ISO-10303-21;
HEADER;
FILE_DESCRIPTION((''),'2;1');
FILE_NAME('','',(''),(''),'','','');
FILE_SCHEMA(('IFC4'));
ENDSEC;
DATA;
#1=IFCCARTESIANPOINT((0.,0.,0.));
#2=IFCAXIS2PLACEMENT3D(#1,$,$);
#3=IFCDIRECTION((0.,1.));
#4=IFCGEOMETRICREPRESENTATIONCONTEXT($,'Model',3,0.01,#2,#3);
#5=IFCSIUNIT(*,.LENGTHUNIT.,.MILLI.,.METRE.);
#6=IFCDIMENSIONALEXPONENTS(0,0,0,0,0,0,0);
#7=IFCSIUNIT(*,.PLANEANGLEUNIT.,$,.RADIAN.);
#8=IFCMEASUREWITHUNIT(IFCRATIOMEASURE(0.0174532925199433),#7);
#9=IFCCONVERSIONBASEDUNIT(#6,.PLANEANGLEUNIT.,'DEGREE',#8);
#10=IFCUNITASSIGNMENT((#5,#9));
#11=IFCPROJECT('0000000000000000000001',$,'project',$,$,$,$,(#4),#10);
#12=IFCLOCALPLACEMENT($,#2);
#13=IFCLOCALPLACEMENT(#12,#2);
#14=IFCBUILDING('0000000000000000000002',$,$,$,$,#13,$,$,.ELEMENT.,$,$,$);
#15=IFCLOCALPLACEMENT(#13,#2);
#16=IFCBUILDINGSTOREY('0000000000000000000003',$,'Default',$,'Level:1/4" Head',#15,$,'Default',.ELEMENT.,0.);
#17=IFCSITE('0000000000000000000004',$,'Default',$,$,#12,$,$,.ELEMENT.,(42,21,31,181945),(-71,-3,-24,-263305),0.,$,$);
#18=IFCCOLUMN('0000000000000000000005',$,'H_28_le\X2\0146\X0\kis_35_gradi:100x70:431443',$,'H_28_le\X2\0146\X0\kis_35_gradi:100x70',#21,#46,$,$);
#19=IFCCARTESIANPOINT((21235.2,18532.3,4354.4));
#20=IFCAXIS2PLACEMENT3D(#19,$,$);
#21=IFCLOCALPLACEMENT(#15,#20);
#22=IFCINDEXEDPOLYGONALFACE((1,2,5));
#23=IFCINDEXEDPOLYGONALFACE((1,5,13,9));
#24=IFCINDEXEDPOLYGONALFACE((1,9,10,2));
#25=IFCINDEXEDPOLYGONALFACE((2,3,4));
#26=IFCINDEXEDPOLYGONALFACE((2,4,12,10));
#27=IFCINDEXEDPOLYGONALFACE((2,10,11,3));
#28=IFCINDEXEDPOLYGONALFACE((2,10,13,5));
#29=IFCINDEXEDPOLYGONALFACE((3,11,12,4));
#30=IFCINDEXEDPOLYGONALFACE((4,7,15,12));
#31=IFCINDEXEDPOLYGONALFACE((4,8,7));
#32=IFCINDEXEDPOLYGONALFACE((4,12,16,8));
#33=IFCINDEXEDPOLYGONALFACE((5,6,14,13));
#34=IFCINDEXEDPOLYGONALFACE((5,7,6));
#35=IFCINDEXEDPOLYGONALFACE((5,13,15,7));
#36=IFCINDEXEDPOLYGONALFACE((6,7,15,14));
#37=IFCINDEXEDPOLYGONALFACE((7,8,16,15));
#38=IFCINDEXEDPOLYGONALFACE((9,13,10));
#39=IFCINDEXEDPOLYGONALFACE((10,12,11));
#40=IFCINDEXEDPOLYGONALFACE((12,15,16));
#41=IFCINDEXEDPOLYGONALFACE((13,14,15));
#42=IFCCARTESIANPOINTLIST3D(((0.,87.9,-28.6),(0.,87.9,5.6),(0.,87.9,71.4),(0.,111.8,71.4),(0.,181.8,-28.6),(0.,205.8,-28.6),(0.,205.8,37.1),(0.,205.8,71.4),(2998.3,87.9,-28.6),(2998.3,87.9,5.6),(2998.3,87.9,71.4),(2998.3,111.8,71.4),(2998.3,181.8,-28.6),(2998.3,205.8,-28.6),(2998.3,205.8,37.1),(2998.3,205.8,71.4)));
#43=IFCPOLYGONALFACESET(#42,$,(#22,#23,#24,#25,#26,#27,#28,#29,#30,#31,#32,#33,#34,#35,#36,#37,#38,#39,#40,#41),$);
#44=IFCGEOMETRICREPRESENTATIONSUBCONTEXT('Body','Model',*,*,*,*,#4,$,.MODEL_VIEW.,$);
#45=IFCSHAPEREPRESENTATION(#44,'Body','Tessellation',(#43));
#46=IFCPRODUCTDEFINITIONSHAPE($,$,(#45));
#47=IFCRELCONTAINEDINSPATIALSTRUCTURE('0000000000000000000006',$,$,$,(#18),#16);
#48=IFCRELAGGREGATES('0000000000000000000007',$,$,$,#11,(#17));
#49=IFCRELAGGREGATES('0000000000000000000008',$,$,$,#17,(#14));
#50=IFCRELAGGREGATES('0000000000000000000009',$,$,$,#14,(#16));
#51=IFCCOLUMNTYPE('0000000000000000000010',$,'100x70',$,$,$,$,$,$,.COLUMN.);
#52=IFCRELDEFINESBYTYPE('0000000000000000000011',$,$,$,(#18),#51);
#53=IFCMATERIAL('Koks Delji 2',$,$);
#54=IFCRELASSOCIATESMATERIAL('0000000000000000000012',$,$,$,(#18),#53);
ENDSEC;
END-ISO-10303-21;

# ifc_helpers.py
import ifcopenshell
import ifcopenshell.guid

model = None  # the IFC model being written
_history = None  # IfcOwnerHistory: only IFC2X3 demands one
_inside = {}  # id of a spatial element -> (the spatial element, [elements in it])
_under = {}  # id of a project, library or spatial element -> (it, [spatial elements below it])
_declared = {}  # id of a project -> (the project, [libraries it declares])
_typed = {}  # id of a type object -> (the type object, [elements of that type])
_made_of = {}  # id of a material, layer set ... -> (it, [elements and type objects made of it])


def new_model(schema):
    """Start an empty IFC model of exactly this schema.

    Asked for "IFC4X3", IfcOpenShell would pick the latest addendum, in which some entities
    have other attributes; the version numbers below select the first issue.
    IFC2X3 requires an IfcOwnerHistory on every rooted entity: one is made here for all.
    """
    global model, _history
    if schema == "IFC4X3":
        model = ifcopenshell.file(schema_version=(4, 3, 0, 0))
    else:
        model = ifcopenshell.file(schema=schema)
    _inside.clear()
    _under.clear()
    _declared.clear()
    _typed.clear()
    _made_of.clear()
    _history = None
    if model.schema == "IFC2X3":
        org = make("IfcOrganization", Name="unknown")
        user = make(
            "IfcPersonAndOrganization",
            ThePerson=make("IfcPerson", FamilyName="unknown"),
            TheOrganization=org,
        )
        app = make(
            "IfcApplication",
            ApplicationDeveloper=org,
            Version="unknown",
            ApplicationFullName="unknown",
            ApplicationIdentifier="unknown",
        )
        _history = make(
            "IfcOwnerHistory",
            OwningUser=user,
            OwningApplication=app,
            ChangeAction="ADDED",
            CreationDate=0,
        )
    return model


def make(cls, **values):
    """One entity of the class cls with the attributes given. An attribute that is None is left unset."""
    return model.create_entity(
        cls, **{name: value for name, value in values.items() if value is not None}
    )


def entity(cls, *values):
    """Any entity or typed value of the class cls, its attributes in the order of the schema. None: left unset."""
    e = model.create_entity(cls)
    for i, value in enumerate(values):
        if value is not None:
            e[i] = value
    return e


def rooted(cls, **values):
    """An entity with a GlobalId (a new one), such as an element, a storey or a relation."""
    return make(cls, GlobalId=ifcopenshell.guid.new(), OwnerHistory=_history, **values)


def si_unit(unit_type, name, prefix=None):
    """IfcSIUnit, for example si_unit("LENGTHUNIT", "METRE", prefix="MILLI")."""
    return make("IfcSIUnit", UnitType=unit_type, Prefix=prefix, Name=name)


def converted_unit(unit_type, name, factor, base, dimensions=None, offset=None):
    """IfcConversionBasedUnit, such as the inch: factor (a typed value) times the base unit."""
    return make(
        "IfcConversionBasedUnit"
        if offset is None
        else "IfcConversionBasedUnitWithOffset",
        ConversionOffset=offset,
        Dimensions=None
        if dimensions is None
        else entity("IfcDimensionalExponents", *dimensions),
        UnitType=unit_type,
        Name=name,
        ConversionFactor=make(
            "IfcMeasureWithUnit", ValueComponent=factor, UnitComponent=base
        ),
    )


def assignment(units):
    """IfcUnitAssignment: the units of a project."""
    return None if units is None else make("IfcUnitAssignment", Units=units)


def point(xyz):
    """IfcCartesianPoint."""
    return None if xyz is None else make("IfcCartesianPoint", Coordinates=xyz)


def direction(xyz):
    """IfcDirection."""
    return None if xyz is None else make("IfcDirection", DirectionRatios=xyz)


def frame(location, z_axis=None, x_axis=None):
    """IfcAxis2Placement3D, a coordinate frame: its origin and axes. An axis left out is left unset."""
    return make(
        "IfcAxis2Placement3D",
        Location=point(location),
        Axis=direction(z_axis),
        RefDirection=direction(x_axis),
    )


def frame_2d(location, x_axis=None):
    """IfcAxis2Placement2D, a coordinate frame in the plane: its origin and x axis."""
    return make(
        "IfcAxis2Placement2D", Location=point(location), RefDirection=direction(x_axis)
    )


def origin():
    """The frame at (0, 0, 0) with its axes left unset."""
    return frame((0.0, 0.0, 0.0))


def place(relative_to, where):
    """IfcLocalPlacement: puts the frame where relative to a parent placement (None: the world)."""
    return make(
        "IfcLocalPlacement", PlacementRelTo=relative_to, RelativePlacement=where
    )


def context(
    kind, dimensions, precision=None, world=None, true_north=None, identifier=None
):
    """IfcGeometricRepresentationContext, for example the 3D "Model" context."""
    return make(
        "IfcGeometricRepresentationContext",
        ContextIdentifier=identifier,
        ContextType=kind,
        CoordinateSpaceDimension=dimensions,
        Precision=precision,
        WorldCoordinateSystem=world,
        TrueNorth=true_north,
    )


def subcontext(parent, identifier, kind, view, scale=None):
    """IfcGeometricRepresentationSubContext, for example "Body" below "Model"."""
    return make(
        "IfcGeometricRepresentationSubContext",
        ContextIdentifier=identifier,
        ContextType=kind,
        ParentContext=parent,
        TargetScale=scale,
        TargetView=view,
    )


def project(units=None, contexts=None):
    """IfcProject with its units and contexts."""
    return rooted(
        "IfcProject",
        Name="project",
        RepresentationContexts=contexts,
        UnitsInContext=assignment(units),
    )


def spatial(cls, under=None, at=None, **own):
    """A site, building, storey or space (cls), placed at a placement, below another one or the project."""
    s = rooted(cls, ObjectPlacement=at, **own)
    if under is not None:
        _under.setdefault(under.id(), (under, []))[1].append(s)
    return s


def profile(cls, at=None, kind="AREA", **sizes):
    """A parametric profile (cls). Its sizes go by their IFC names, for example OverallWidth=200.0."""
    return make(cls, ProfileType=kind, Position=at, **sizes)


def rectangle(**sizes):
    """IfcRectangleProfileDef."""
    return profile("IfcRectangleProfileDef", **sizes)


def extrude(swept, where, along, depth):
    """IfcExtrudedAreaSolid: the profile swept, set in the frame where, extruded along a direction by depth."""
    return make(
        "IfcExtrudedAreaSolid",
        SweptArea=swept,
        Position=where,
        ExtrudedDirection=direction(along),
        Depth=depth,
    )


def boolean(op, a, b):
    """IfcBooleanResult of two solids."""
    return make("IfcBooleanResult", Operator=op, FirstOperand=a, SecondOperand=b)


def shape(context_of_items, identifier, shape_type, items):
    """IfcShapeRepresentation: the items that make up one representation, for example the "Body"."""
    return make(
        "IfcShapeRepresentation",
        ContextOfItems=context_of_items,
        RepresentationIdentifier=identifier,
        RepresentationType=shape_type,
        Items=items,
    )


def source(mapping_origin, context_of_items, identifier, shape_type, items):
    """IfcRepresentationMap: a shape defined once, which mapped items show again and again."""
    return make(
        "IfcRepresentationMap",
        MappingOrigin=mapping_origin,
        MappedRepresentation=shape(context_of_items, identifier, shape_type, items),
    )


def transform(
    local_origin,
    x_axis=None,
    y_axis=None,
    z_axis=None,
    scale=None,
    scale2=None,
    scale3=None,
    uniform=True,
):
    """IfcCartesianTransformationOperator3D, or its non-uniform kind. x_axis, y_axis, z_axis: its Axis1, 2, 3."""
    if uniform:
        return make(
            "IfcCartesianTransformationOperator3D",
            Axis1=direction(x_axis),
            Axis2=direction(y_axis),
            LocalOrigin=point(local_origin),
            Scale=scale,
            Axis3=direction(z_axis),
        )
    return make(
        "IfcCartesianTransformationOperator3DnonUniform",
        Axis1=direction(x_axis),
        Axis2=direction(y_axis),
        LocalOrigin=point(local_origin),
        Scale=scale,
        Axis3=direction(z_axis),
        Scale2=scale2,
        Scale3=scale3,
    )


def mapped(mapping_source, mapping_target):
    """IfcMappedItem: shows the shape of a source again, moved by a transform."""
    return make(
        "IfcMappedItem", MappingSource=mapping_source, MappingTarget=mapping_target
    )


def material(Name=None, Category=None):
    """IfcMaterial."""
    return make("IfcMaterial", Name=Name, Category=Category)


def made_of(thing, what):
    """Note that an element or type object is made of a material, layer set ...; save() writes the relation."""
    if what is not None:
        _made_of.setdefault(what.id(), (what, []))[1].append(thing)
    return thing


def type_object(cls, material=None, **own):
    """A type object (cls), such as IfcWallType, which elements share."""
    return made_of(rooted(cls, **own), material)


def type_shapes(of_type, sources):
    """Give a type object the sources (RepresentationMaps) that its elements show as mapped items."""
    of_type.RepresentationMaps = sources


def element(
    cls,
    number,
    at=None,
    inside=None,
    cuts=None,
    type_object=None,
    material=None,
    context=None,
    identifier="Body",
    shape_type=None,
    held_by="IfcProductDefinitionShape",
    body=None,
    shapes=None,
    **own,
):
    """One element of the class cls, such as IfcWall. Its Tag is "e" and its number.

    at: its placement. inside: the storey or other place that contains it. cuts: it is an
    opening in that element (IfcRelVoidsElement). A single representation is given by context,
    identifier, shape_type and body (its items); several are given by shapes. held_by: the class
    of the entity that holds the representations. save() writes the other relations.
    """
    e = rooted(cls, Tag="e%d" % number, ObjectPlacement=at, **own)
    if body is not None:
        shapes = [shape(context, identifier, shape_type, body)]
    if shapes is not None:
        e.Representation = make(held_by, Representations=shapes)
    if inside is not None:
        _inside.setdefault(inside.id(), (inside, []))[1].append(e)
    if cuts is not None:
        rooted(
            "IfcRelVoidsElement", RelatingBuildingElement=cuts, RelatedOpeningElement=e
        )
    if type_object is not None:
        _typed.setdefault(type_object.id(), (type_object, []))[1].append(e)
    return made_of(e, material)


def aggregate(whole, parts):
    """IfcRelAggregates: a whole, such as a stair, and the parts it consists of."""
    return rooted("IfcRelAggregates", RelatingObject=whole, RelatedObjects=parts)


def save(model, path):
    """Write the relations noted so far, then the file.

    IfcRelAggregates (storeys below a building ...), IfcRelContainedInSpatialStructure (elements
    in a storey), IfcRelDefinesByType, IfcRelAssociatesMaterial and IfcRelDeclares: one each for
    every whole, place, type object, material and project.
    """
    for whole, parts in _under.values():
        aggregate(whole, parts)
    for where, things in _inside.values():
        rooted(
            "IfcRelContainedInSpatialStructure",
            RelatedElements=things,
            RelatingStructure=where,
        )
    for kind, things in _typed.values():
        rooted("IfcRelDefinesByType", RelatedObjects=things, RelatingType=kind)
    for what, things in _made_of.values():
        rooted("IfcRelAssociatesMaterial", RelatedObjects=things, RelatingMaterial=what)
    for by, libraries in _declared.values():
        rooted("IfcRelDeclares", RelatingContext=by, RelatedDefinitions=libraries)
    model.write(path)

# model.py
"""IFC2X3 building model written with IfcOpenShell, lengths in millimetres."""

from ifc_helpers import new_model, entity, si_unit, converted_unit, direction, frame, frame_2d, origin, place, context, subcontext, project, spatial, rectangle, extrude, boolean, source, transform, mapped, material, type_object, type_shapes, element, save


model = new_model("IFC2X3")

# Units and contexts
model_context = context("Model", 3, precision=0.01, world=origin(), true_north=direction((0.0, 1.0)))
body_context = subcontext(model_context, "Body", "Model", "MODEL_VIEW")
ifc_project = project(units=[si_unit("LENGTHUNIT", "METRE", prefix="MILLI"), converted_unit("PLANEANGLEUNIT", "DEGREE", entity("IfcRatioMeasure", 0.0174532925199433), si_unit("PLANEANGLEUNIT", "RADIAN"), dimensions=[0, 0, 0, 0, 0, 0, 0])], contexts=[model_context])

# Site, building, storey
site_placement = place(None, origin())
site = spatial("IfcSite", under=ifc_project, at=site_placement, Name="Default", CompositionType="ELEMENT", RefLatitude=(42, 21, 31, 181945), RefLongitude=(-71, -3, -24, -263305), RefElevation=0.0)
building_placement = place(site_placement, origin())
building = spatial("IfcBuilding", under=site, at=building_placement, CompositionType="ELEMENT")
storey_placement = place(building_placement, origin())
storey = spatial("IfcBuildingStorey", under=building, at=storey_placement, Name="Default", ObjectType="Level:1/4\" Head", LongName="Default", CompositionType="ELEMENT", Elevation=0.0)

# Column
ifc_material_1 = material(Name="Koks Delji 2")
column_type = type_object("IfcColumnType", Name="100x70", PredefinedType="COLUMN")
shared_shape_1 = source(origin(), body_context, "Body", "CSG", [
    boolean("DIFFERENCE", extrude(rectangle(XDim=2998.3, YDim=117.9, at=frame_2d((0.0, 0.0), x_axis=(1.0, 0.0))), frame((1499.1, 146.8, -28.6)), (0.0, 0.0, 1.0), 100.0), extrude(rectangle(XDim=70.0, YDim=100.0, at=frame_2d((0.0, 0.0), x_axis=(0.0, 1.0))), frame((2998.3, 146.8, 21.4), z_axis=(1.0, 0.0, 0.0), x_axis=(0.0, 0.939693, -0.34202)), (0.0, 0.0, -1.0), 2998.3)),
])
type_shapes(column_type, [shared_shape_1])
column_placement = place(storey_placement, frame((21235.2, 18532.3, 4354.4)))
element("IfcColumn", 1, at=column_placement, inside=storey, type_object=column_type, material=ifc_material_1, Name="H_28_leņkis_35_gradi:100x70:431443", ObjectType="H_28_leņkis_35_gradi:100x70", context=body_context, shape_type="MappedRepresentation", body=[
    mapped(shared_shape_1, transform((0.0, 0.0, 0.0), scale=1.0)),
])

save(model, "model.ifc")
